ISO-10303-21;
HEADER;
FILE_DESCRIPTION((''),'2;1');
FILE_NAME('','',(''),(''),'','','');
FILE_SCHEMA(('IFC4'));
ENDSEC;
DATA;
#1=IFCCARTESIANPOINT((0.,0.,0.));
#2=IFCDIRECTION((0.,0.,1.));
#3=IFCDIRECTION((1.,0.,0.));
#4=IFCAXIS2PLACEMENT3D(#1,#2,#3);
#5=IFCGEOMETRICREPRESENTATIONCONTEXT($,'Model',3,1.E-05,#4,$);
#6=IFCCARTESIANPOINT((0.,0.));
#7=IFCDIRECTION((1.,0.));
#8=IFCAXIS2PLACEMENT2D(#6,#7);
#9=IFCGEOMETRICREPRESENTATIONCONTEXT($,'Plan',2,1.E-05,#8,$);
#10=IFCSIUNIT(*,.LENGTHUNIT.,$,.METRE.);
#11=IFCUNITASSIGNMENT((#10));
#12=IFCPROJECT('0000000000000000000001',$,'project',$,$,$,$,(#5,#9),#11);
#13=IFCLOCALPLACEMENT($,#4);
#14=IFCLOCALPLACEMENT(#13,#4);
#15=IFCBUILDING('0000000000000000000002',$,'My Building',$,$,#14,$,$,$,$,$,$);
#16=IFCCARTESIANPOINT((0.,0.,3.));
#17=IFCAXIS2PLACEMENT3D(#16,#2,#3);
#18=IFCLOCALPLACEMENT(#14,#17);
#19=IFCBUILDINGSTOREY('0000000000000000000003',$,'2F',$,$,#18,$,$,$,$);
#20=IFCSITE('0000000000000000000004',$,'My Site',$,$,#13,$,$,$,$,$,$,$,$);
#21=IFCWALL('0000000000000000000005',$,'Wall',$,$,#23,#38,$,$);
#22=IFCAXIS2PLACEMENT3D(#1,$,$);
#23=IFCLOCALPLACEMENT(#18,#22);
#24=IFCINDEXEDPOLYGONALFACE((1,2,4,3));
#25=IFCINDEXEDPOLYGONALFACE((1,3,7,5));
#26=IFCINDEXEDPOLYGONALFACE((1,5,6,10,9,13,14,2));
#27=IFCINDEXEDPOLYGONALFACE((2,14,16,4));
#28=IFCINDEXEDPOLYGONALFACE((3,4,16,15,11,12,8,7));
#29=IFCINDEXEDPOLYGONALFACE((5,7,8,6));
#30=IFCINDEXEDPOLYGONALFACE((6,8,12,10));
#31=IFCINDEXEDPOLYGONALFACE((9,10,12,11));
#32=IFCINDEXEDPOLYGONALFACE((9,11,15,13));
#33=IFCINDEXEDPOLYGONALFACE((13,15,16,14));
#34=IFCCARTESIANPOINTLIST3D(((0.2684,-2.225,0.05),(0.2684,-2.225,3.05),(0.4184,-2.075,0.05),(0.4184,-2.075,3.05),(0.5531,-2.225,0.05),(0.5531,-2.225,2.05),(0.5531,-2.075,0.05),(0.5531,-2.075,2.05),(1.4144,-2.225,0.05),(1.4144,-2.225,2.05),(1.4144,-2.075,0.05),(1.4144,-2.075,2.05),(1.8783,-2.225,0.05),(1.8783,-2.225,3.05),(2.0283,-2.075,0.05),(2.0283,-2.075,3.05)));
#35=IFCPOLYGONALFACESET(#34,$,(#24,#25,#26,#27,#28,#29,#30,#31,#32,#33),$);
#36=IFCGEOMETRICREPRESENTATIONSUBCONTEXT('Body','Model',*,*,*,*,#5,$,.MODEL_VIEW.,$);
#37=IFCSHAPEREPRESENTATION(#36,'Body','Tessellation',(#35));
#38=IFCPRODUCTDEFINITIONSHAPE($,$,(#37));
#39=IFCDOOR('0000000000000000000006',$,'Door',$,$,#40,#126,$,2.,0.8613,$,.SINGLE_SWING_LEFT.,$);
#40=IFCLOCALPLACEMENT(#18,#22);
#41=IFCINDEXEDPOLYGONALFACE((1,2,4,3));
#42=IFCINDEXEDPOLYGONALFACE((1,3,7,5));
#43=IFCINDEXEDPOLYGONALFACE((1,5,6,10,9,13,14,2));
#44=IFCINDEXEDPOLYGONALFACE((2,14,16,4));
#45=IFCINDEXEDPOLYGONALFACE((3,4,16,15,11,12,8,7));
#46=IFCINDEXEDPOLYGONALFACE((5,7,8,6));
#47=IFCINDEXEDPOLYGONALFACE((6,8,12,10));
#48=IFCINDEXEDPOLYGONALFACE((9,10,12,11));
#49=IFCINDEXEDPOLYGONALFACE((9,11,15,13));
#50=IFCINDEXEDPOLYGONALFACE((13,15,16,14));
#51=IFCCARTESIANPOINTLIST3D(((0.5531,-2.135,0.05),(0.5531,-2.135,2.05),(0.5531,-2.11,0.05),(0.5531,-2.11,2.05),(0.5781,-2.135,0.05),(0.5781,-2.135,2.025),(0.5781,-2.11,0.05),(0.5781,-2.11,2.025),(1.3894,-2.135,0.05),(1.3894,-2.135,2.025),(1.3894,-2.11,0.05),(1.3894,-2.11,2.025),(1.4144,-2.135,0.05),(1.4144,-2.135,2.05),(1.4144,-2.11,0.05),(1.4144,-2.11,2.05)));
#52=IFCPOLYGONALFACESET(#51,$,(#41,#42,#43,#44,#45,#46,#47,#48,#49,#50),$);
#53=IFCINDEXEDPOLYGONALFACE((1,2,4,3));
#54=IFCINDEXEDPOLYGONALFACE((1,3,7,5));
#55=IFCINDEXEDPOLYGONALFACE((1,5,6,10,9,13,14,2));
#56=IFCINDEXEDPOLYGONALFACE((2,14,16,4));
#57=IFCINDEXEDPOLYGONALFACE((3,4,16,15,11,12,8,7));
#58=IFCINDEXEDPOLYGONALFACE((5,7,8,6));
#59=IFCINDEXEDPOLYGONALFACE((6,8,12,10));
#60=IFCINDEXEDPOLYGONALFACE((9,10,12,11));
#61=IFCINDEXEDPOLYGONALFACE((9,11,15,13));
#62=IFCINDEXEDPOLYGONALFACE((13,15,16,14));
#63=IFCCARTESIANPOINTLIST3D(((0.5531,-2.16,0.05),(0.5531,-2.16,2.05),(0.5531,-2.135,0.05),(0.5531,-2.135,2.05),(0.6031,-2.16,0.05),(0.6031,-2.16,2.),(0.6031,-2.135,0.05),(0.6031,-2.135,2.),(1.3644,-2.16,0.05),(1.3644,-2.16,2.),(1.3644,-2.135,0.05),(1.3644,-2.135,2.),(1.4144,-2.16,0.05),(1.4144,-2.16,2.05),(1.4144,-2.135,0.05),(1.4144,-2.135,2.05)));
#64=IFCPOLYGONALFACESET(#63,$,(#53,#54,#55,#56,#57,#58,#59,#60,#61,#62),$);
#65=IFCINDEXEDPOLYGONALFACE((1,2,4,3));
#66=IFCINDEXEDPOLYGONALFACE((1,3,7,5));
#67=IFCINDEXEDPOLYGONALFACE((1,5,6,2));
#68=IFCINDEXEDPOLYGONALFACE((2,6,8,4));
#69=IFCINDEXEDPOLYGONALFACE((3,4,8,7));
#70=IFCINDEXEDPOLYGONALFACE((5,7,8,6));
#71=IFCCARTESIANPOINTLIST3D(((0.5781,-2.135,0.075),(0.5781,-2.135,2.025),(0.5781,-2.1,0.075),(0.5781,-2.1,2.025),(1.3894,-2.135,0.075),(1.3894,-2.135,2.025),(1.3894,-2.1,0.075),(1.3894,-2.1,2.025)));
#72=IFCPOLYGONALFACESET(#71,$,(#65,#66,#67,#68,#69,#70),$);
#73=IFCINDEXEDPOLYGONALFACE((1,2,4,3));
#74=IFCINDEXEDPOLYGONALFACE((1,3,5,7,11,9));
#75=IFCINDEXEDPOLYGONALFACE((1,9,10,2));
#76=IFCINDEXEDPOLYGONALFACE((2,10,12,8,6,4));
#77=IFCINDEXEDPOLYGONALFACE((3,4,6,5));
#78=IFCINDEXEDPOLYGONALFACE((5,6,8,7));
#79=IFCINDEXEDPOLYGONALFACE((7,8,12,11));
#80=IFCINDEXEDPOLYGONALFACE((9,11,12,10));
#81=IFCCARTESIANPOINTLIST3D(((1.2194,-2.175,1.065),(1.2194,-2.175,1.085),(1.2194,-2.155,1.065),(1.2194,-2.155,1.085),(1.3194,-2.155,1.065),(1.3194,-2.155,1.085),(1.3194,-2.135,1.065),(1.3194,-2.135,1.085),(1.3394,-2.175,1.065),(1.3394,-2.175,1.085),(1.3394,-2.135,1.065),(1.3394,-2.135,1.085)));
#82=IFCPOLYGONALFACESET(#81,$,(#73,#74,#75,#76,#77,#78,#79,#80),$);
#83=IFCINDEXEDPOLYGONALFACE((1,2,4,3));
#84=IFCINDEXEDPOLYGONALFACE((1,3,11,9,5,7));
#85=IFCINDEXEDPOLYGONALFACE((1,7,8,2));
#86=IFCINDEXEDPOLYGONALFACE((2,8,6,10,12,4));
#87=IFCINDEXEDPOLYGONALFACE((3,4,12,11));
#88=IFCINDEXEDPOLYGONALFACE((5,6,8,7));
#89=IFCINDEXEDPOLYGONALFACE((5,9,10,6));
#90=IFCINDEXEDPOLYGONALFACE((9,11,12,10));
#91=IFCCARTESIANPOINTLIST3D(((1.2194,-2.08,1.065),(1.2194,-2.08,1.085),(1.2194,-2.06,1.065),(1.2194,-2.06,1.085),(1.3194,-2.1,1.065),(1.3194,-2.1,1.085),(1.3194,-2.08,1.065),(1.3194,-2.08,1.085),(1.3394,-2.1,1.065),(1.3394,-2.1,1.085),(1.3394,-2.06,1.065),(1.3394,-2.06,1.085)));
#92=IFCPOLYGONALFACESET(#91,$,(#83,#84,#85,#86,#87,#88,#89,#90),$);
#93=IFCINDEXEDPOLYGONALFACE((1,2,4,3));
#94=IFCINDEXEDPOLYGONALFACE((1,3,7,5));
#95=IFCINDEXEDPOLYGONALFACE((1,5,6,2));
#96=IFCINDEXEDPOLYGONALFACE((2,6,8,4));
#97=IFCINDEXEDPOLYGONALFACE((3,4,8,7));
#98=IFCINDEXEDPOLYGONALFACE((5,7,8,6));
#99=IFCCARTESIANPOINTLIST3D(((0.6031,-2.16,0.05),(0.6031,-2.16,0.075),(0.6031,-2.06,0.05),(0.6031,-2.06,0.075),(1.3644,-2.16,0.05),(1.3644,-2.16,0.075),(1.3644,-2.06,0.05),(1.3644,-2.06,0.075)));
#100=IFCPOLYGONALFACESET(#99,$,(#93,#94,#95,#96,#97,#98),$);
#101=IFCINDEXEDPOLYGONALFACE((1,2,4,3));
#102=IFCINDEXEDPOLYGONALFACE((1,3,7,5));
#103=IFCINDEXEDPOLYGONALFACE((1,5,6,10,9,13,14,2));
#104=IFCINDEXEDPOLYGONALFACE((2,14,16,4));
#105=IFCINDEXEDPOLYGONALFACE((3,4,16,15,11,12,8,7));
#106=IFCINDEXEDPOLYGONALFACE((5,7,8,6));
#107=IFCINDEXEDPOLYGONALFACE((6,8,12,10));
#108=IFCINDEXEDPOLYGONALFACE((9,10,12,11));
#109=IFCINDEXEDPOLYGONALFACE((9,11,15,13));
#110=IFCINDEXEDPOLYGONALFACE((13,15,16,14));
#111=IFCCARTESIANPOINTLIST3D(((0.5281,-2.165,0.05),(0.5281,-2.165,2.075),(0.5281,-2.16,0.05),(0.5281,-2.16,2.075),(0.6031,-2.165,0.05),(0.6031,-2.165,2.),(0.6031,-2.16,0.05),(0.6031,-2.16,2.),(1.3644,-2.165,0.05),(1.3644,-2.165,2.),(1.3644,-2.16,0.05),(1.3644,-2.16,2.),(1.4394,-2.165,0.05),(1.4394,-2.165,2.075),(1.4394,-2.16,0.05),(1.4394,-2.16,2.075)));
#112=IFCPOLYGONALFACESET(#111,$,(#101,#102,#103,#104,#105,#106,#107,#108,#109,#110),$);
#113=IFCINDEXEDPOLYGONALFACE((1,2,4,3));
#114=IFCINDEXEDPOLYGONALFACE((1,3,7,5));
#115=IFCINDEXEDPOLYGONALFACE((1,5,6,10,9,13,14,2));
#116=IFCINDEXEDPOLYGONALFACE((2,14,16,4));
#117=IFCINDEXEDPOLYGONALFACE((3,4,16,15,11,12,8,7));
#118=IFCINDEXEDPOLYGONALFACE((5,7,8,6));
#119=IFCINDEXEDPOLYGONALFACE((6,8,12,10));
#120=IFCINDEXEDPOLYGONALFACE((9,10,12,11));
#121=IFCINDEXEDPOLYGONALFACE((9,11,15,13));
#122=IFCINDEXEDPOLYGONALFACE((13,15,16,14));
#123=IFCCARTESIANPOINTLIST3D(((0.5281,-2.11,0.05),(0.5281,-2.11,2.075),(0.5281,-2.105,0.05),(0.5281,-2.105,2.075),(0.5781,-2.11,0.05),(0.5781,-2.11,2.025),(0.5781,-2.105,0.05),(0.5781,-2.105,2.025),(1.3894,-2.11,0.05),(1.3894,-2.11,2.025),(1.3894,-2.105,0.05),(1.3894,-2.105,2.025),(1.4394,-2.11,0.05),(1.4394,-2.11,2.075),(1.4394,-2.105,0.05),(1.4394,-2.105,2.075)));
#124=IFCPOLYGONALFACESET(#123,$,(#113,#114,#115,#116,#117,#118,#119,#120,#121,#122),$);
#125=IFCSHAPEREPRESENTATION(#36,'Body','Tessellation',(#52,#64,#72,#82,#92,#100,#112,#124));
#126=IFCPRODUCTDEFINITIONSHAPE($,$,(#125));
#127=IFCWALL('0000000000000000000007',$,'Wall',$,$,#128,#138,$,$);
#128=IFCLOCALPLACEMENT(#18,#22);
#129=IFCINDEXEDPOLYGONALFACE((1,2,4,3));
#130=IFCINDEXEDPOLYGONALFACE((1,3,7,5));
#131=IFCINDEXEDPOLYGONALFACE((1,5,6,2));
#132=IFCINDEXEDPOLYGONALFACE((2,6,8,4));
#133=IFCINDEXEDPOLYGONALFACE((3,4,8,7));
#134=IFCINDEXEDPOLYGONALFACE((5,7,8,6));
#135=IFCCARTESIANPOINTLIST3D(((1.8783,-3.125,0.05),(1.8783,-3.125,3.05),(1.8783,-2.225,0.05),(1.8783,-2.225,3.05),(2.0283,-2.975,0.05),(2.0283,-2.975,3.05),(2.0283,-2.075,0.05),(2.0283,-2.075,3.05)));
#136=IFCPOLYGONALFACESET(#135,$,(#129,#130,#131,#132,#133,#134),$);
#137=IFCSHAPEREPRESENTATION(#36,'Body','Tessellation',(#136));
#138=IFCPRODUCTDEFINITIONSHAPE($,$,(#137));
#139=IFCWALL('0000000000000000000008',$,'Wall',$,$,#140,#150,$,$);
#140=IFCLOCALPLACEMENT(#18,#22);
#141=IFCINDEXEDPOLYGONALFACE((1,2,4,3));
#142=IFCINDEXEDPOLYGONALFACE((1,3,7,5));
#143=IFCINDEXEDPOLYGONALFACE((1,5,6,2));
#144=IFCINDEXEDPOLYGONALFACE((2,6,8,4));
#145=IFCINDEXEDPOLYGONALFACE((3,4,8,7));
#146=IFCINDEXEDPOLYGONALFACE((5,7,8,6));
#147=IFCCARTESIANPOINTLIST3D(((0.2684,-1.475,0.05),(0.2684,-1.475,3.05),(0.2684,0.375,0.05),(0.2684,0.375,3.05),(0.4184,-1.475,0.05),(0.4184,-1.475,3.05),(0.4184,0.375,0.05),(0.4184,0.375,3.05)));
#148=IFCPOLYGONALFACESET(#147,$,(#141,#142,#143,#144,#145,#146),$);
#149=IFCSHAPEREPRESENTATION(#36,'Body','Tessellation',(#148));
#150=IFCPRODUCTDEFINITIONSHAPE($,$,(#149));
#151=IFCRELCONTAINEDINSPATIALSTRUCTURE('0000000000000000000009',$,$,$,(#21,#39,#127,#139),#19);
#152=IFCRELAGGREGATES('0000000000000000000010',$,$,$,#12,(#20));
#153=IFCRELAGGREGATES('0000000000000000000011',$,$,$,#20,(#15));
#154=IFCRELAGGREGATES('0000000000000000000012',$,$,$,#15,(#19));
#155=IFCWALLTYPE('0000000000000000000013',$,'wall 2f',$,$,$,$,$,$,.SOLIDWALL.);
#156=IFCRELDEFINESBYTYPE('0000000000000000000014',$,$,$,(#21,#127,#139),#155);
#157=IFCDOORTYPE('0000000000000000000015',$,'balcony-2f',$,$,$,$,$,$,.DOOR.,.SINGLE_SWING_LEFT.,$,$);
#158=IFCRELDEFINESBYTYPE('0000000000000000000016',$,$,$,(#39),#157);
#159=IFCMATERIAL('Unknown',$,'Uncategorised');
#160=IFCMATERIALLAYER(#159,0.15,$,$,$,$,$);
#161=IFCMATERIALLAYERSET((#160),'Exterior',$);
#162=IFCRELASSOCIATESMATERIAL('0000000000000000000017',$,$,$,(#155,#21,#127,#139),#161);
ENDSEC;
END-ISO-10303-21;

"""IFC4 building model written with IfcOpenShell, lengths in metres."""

from ifc_helpers import new_model, entity, si_unit, frame, origin_with_axes, origin_2d_with_axis, place, context, subcontext, project, spatial, line, indexed_curve, outline, extrude, shape, source, transform, mapped, material, layer, layer_set, layer_usage, type_object, type_shapes, element, fill, save


model = new_model("IFC4")

# Units and contexts
model_context = context("Model", 3, precision=1e-05, world=origin_with_axes())
plan_context = context("Plan", 2, precision=1e-05, world=origin_2d_with_axis())
body_context_1 = subcontext(model_context, "Body", "Model", "MODEL_VIEW")
body_context_2 = subcontext(plan_context, "Body", "Plan", "PLAN_VIEW")
ifc_project = project(units=[si_unit("LENGTHUNIT", "METRE")], contexts=[model_context, plan_context])

# Site, building, storey
site_placement = place(None, origin_with_axes())
site = spatial("IfcSite", under=ifc_project, at=site_placement, Name="My Site")
building_placement = place(site_placement, origin_with_axes())
building = spatial("IfcBuilding", under=site, at=building_placement, Name="My Building")
storey_placement = place(building_placement, frame((0.0, 0.0, 3.0), z_axis=(0.0, 0.0, 1.0), x_axis=(1.0, 0.0, 0.0)))
storey = spatial("IfcBuildingStorey", under=building, at=storey_placement, Name="2F")

# Shared definitions
ifc_material = material(Name="Unknown", Category="Uncategorised")

# Shared definitions
ifc_layer_1 = layer(ifc_material, 0.15)
ifc_layer_set_1 = layer_set([ifc_layer_1], Name="Exterior")
wall_type_1 = type_object("IfcWallType", Name="wall 2f", PredefinedType="SOLIDWALL", material=ifc_layer_set_1)

# Wall, opening, door
ifc_layer_usage_1 = layer_usage(ifc_layer_set_1, "AXIS2", "POSITIVE", 0.0)
wall_1_placement = place(storey_placement, frame((0.2684, -2.225, 0.05), z_axis=(0.0, 0.0, 1.0), x_axis=(1.0, 0.0, 0.0)))
wall_1 = element("IfcWall", 1, at=wall_1_placement, inside=storey, type_object=wall_type_1, material=ifc_layer_usage_1, Name="Wall", context=body_context_1, shape_type="SweptSolid", body=[
    extrude(outline(indexed_curve([(0.0, 0.0), (0.15, 0.15), (1.76, 0.15), (1.61, 0.0)], segments=[line(1, 2, 3, 4, 1)])), origin_with_axes(), (0.0, 0.0, 1.0), 3.0),
])
shared_shape_1 = source(origin_with_axes(), body_context_1, "Body", "SweptSolid", [
    extrude(outline(indexed_curve([(0.0, 0.0), (0.8613, 0.0), (0.8613, 2.0), (0.0, 2.0)], segments=[line(1, 2, 3, 4, 1)])), frame((0.0, -0.6, 0.0), z_axis=(0.0, -1.0, 0.0), x_axis=(1.0, 0.0, 0.0)), (0.0, 0.0, -1.0), 1.2),
])
opening_1_placement = place(wall_1_placement, frame((0.2847, 0.065, 0.0), z_axis=(0.0, 0.0, 1.0), x_axis=(1.0, 0.0, 0.0)))
opening_1 = element("IfcOpeningElement", 2, at=opening_1_placement, cuts=wall_1, PredefinedType="OPENING", context=body_context_1, shape_type="MappedRepresentation", body=[
    mapped(shared_shape_1, transform((0.0, 0.0, 0.0), x_axis=(1.0, 0.0, 0.0), y_axis=(0.0, 1.0, 0.0), z_axis=(0.0, 0.0, 1.0), scale=1.0)),
])
door_type_1 = type_object("IfcDoorType", Name="balcony-2f", OperationType="SINGLE_SWING_LEFT", PredefinedType="DOOR")
shared_shape_2 = source(origin_with_axes(), body_context_1, "Body", "SweptSolid", [
    extrude(outline(indexed_curve([(0.0, 0.0), (0.0, 2.0), (0.8613, 2.0), (0.8613, 0.0), (0.8363, 0.0), (0.8363, 1.975), (0.025, 1.975), (0.025, 0.0)], segments=[line(1, 2, 3, 4, 5, 6, 7, 8, 1)])), frame((0.0, 0.025, 0.0), z_axis=(0.0, -1.0, 0.0), x_axis=(1.0, 0.0, 0.0)), (0.0, 0.0, -1.0), 0.025),
    extrude(outline(indexed_curve([(0.0, 0.0), (0.0, 2.0), (0.8613, 2.0), (0.8613, 0.0), (0.8113, 0.0), (0.8113, 1.95), (0.05, 1.95), (0.05, 0.0)], segments=[line(1, 2, 3, 4, 5, 6, 7, 8, 1)])), frame((0.0, 0.0, 0.0), z_axis=(0.0, -1.0, 0.0), x_axis=(1.0, 0.0, 0.0)), (0.0, 0.0, -1.0), 0.025),
    extrude(outline(indexed_curve([(0.0, 0.0), (0.8113, 0.0), (0.8113, 0.035), (0.0, 0.035)], segments=[line(1, 2, 3, 4, 1)])), frame((0.025, 0.025, 0.025), z_axis=(0.0, 0.0, 1.0), x_axis=(1.0, 0.0, 0.0)), (0.0, 0.0, 1.0), 1.95),
    extrude(outline(indexed_curve([(0.0, 0.0), (0.0, -0.04), (-0.12, -0.04), (-0.12, -0.02), (-0.02, -0.02), (-0.02, 0.0)], segments=[line(1, 2, 3, 4, 5, 6, 1)])), frame((0.7863, 0.025, 1.015), z_axis=(0.0, 0.0, 1.0), x_axis=(1.0, 0.0, 0.0)), (0.0, 0.0, 1.0), 0.02),
    extrude(outline(indexed_curve([(0.0, 0.0), (0.0, 0.04), (-0.12, 0.04), (-0.12, 0.02), (-0.02, 0.02), (-0.02, 0.0)], segments=[line(1, 2, 3, 4, 5, 6, 1)])), frame((0.7863, 0.06, 1.015), z_axis=(0.0, 0.0, 1.0), x_axis=(1.0, 0.0, 0.0)), (0.0, 0.0, 1.0), 0.02),
    extrude(outline(indexed_curve([(0.0, 0.0), (0.7613, 0.0), (0.7613, 0.1), (0.0, 0.1)], segments=[line(1, 2, 3, 4, 1)])), frame((0.05, 0.0, 0.0), z_axis=(0.0, 0.0, 1.0), x_axis=(1.0, 0.0, 0.0)), (0.0, 0.0, 1.0), 0.025),
    extrude(outline(indexed_curve([(0.0, 0.0), (0.0, 2.025), (0.9113, 2.025), (0.9113, 0.0), (0.8363, 0.0), (0.8363, 1.95), (0.075, 1.95), (0.075, 0.0)], segments=[line(1, 2, 3, 4, 5, 6, 7, 8, 1)])), frame((-0.025, -0.005, 0.0), z_axis=(0.0, -1.0, 0.0), x_axis=(1.0, 0.0, 0.0)), (0.0, 0.0, -1.0), 0.005),
    extrude(outline(indexed_curve([(0.0, 0.0), (0.0, 2.025), (0.9113, 2.025), (0.9113, 0.0), (0.8613, 0.0), (0.8613, 1.975), (0.05, 1.975), (0.05, 0.0)], segments=[line(1, 2, 3, 4, 5, 6, 7, 8, 1)])), frame((-0.025, 0.05, 0.0), z_axis=(0.0, -1.0, 0.0), x_axis=(1.0, 0.0, 0.0)), (0.0, 0.0, -1.0), 0.005),
])
shared_shape_3 = source(origin_with_axes(), body_context_2, "Body", "Curve2D", [
    entity("IfcIndexedPolyCurve", entity("IfcCartesianPointList2D", [[0.0, 0.0], [0.0, 0.05], [0.025, 0.05], [0.025, 0.025], [0.05, 0.025], [0.05, 0.0]]), [entity("IfcLineIndex", [1, 2, 3, 4, 5, 6, 1])]),
    entity("IfcIndexedPolyCurve", entity("IfcCartesianPointList2D", [[0.8613, 0.0], [0.8613, 0.05], [0.8363, 0.05], [0.8363, 0.025], [0.8113, 0.025], [0.8113, 0.0]]), [entity("IfcLineIndex", [1, 2, 3, 4, 5, 6, 1])]),
    entity("IfcTrimmedCurve", entity("IfcEllipse", entity("IfcAxis2Placement2D", entity("IfcCartesianPoint", [0.06, 0.05]), entity("IfcDirection", [1.0, 0.0])), 0.7763, 0.8113), [entity("IfcCartesianPoint", [0.8363, 0.05])], [entity("IfcCartesianPoint", [0.06, 0.8613])], True, "CARTESIAN"),
    entity("IfcIndexedPolyCurve", entity("IfcCartesianPointList2D", [[0.025, 0.05], [0.06, 0.05], [0.06, 0.8613], [0.025, 0.8613]]), [entity("IfcLineIndex", [1, 2, 3, 4, 1])]),
])
type_shapes(door_type_1, [shared_shape_2, shared_shape_3])
door_1_placement = place(opening_1_placement, frame((0.0, 0.0, 0.0), z_axis=(0.0, 0.0, 1.0), x_axis=(1.0, 0.0, 0.0)))
door_1 = element("IfcDoor", 3, at=door_1_placement, inside=storey, type_object=door_type_1, Name="Door", OperationType="SINGLE_SWING_LEFT", OverallHeight=2.0, OverallWidth=0.8613, shapes=[
    shape(body_context_1, "Body", "MappedRepresentation", [mapped(shared_shape_2, transform((0.0, 0.0, 0.0), x_axis=(1.0, 0.0, 0.0), y_axis=(0.0, 1.0, 0.0), z_axis=(0.0, 0.0, 1.0), scale=1.0))]),
    shape(body_context_2, "Body", "MappedRepresentation", [mapped(shared_shape_3, transform((0.0, 0.0, 0.0), x_axis=(1.0, 0.0, 0.0), y_axis=(0.0, 1.0, 0.0), z_axis=(0.0, 0.0, 1.0), scale=1.0))]),
])
fill(opening_1, door_1)

# Wall
ifc_layer_usage_2 = layer_usage(ifc_layer_set_1, "AXIS2", "POSITIVE", 0.0)
wall_2_placement = place(storey_placement, frame((1.8783, -2.225, 0.05), z_axis=(0.0, 0.0, 1.0), x_axis=(0.0, -1.0, 0.0)))
element("IfcWall", 4, at=wall_2_placement, inside=storey, type_object=wall_type_1, material=ifc_layer_usage_2, Name="Wall", context=body_context_1, shape_type="SweptSolid", body=[
    extrude(outline(indexed_curve([(0.0, 0.0), (-0.15, 0.15), (0.75, 0.15), (0.9, 0.0)], segments=[line(1, 2, 3, 4, 1)])), origin_with_axes(), (0.0, 0.0, 1.0), 3.0),
])

# Wall
ifc_layer_usage_3 = layer_usage(ifc_layer_set_1, "AXIS2", "POSITIVE", 0.0)
wall_3_placement = place(storey_placement, frame((0.2684, 0.375, 0.05), z_axis=(0.0, 0.0, 1.0), x_axis=(0.0, -1.0, 0.0)))
element("IfcWall", 5, at=wall_3_placement, inside=storey, type_object=wall_type_1, material=ifc_layer_usage_3, Name="Wall", context=body_context_1, shape_type="SweptSolid", body=[
    extrude(outline(indexed_curve([(0.0, 0.0), (0.0, 0.15), (1.85, 0.15), (1.85, 0.0)], segments=[line(1, 2, 3, 4, 1)])), origin_with_axes(), (0.0, 0.0, 1.0), 3.0),
])

save(model, "model.ifc")
